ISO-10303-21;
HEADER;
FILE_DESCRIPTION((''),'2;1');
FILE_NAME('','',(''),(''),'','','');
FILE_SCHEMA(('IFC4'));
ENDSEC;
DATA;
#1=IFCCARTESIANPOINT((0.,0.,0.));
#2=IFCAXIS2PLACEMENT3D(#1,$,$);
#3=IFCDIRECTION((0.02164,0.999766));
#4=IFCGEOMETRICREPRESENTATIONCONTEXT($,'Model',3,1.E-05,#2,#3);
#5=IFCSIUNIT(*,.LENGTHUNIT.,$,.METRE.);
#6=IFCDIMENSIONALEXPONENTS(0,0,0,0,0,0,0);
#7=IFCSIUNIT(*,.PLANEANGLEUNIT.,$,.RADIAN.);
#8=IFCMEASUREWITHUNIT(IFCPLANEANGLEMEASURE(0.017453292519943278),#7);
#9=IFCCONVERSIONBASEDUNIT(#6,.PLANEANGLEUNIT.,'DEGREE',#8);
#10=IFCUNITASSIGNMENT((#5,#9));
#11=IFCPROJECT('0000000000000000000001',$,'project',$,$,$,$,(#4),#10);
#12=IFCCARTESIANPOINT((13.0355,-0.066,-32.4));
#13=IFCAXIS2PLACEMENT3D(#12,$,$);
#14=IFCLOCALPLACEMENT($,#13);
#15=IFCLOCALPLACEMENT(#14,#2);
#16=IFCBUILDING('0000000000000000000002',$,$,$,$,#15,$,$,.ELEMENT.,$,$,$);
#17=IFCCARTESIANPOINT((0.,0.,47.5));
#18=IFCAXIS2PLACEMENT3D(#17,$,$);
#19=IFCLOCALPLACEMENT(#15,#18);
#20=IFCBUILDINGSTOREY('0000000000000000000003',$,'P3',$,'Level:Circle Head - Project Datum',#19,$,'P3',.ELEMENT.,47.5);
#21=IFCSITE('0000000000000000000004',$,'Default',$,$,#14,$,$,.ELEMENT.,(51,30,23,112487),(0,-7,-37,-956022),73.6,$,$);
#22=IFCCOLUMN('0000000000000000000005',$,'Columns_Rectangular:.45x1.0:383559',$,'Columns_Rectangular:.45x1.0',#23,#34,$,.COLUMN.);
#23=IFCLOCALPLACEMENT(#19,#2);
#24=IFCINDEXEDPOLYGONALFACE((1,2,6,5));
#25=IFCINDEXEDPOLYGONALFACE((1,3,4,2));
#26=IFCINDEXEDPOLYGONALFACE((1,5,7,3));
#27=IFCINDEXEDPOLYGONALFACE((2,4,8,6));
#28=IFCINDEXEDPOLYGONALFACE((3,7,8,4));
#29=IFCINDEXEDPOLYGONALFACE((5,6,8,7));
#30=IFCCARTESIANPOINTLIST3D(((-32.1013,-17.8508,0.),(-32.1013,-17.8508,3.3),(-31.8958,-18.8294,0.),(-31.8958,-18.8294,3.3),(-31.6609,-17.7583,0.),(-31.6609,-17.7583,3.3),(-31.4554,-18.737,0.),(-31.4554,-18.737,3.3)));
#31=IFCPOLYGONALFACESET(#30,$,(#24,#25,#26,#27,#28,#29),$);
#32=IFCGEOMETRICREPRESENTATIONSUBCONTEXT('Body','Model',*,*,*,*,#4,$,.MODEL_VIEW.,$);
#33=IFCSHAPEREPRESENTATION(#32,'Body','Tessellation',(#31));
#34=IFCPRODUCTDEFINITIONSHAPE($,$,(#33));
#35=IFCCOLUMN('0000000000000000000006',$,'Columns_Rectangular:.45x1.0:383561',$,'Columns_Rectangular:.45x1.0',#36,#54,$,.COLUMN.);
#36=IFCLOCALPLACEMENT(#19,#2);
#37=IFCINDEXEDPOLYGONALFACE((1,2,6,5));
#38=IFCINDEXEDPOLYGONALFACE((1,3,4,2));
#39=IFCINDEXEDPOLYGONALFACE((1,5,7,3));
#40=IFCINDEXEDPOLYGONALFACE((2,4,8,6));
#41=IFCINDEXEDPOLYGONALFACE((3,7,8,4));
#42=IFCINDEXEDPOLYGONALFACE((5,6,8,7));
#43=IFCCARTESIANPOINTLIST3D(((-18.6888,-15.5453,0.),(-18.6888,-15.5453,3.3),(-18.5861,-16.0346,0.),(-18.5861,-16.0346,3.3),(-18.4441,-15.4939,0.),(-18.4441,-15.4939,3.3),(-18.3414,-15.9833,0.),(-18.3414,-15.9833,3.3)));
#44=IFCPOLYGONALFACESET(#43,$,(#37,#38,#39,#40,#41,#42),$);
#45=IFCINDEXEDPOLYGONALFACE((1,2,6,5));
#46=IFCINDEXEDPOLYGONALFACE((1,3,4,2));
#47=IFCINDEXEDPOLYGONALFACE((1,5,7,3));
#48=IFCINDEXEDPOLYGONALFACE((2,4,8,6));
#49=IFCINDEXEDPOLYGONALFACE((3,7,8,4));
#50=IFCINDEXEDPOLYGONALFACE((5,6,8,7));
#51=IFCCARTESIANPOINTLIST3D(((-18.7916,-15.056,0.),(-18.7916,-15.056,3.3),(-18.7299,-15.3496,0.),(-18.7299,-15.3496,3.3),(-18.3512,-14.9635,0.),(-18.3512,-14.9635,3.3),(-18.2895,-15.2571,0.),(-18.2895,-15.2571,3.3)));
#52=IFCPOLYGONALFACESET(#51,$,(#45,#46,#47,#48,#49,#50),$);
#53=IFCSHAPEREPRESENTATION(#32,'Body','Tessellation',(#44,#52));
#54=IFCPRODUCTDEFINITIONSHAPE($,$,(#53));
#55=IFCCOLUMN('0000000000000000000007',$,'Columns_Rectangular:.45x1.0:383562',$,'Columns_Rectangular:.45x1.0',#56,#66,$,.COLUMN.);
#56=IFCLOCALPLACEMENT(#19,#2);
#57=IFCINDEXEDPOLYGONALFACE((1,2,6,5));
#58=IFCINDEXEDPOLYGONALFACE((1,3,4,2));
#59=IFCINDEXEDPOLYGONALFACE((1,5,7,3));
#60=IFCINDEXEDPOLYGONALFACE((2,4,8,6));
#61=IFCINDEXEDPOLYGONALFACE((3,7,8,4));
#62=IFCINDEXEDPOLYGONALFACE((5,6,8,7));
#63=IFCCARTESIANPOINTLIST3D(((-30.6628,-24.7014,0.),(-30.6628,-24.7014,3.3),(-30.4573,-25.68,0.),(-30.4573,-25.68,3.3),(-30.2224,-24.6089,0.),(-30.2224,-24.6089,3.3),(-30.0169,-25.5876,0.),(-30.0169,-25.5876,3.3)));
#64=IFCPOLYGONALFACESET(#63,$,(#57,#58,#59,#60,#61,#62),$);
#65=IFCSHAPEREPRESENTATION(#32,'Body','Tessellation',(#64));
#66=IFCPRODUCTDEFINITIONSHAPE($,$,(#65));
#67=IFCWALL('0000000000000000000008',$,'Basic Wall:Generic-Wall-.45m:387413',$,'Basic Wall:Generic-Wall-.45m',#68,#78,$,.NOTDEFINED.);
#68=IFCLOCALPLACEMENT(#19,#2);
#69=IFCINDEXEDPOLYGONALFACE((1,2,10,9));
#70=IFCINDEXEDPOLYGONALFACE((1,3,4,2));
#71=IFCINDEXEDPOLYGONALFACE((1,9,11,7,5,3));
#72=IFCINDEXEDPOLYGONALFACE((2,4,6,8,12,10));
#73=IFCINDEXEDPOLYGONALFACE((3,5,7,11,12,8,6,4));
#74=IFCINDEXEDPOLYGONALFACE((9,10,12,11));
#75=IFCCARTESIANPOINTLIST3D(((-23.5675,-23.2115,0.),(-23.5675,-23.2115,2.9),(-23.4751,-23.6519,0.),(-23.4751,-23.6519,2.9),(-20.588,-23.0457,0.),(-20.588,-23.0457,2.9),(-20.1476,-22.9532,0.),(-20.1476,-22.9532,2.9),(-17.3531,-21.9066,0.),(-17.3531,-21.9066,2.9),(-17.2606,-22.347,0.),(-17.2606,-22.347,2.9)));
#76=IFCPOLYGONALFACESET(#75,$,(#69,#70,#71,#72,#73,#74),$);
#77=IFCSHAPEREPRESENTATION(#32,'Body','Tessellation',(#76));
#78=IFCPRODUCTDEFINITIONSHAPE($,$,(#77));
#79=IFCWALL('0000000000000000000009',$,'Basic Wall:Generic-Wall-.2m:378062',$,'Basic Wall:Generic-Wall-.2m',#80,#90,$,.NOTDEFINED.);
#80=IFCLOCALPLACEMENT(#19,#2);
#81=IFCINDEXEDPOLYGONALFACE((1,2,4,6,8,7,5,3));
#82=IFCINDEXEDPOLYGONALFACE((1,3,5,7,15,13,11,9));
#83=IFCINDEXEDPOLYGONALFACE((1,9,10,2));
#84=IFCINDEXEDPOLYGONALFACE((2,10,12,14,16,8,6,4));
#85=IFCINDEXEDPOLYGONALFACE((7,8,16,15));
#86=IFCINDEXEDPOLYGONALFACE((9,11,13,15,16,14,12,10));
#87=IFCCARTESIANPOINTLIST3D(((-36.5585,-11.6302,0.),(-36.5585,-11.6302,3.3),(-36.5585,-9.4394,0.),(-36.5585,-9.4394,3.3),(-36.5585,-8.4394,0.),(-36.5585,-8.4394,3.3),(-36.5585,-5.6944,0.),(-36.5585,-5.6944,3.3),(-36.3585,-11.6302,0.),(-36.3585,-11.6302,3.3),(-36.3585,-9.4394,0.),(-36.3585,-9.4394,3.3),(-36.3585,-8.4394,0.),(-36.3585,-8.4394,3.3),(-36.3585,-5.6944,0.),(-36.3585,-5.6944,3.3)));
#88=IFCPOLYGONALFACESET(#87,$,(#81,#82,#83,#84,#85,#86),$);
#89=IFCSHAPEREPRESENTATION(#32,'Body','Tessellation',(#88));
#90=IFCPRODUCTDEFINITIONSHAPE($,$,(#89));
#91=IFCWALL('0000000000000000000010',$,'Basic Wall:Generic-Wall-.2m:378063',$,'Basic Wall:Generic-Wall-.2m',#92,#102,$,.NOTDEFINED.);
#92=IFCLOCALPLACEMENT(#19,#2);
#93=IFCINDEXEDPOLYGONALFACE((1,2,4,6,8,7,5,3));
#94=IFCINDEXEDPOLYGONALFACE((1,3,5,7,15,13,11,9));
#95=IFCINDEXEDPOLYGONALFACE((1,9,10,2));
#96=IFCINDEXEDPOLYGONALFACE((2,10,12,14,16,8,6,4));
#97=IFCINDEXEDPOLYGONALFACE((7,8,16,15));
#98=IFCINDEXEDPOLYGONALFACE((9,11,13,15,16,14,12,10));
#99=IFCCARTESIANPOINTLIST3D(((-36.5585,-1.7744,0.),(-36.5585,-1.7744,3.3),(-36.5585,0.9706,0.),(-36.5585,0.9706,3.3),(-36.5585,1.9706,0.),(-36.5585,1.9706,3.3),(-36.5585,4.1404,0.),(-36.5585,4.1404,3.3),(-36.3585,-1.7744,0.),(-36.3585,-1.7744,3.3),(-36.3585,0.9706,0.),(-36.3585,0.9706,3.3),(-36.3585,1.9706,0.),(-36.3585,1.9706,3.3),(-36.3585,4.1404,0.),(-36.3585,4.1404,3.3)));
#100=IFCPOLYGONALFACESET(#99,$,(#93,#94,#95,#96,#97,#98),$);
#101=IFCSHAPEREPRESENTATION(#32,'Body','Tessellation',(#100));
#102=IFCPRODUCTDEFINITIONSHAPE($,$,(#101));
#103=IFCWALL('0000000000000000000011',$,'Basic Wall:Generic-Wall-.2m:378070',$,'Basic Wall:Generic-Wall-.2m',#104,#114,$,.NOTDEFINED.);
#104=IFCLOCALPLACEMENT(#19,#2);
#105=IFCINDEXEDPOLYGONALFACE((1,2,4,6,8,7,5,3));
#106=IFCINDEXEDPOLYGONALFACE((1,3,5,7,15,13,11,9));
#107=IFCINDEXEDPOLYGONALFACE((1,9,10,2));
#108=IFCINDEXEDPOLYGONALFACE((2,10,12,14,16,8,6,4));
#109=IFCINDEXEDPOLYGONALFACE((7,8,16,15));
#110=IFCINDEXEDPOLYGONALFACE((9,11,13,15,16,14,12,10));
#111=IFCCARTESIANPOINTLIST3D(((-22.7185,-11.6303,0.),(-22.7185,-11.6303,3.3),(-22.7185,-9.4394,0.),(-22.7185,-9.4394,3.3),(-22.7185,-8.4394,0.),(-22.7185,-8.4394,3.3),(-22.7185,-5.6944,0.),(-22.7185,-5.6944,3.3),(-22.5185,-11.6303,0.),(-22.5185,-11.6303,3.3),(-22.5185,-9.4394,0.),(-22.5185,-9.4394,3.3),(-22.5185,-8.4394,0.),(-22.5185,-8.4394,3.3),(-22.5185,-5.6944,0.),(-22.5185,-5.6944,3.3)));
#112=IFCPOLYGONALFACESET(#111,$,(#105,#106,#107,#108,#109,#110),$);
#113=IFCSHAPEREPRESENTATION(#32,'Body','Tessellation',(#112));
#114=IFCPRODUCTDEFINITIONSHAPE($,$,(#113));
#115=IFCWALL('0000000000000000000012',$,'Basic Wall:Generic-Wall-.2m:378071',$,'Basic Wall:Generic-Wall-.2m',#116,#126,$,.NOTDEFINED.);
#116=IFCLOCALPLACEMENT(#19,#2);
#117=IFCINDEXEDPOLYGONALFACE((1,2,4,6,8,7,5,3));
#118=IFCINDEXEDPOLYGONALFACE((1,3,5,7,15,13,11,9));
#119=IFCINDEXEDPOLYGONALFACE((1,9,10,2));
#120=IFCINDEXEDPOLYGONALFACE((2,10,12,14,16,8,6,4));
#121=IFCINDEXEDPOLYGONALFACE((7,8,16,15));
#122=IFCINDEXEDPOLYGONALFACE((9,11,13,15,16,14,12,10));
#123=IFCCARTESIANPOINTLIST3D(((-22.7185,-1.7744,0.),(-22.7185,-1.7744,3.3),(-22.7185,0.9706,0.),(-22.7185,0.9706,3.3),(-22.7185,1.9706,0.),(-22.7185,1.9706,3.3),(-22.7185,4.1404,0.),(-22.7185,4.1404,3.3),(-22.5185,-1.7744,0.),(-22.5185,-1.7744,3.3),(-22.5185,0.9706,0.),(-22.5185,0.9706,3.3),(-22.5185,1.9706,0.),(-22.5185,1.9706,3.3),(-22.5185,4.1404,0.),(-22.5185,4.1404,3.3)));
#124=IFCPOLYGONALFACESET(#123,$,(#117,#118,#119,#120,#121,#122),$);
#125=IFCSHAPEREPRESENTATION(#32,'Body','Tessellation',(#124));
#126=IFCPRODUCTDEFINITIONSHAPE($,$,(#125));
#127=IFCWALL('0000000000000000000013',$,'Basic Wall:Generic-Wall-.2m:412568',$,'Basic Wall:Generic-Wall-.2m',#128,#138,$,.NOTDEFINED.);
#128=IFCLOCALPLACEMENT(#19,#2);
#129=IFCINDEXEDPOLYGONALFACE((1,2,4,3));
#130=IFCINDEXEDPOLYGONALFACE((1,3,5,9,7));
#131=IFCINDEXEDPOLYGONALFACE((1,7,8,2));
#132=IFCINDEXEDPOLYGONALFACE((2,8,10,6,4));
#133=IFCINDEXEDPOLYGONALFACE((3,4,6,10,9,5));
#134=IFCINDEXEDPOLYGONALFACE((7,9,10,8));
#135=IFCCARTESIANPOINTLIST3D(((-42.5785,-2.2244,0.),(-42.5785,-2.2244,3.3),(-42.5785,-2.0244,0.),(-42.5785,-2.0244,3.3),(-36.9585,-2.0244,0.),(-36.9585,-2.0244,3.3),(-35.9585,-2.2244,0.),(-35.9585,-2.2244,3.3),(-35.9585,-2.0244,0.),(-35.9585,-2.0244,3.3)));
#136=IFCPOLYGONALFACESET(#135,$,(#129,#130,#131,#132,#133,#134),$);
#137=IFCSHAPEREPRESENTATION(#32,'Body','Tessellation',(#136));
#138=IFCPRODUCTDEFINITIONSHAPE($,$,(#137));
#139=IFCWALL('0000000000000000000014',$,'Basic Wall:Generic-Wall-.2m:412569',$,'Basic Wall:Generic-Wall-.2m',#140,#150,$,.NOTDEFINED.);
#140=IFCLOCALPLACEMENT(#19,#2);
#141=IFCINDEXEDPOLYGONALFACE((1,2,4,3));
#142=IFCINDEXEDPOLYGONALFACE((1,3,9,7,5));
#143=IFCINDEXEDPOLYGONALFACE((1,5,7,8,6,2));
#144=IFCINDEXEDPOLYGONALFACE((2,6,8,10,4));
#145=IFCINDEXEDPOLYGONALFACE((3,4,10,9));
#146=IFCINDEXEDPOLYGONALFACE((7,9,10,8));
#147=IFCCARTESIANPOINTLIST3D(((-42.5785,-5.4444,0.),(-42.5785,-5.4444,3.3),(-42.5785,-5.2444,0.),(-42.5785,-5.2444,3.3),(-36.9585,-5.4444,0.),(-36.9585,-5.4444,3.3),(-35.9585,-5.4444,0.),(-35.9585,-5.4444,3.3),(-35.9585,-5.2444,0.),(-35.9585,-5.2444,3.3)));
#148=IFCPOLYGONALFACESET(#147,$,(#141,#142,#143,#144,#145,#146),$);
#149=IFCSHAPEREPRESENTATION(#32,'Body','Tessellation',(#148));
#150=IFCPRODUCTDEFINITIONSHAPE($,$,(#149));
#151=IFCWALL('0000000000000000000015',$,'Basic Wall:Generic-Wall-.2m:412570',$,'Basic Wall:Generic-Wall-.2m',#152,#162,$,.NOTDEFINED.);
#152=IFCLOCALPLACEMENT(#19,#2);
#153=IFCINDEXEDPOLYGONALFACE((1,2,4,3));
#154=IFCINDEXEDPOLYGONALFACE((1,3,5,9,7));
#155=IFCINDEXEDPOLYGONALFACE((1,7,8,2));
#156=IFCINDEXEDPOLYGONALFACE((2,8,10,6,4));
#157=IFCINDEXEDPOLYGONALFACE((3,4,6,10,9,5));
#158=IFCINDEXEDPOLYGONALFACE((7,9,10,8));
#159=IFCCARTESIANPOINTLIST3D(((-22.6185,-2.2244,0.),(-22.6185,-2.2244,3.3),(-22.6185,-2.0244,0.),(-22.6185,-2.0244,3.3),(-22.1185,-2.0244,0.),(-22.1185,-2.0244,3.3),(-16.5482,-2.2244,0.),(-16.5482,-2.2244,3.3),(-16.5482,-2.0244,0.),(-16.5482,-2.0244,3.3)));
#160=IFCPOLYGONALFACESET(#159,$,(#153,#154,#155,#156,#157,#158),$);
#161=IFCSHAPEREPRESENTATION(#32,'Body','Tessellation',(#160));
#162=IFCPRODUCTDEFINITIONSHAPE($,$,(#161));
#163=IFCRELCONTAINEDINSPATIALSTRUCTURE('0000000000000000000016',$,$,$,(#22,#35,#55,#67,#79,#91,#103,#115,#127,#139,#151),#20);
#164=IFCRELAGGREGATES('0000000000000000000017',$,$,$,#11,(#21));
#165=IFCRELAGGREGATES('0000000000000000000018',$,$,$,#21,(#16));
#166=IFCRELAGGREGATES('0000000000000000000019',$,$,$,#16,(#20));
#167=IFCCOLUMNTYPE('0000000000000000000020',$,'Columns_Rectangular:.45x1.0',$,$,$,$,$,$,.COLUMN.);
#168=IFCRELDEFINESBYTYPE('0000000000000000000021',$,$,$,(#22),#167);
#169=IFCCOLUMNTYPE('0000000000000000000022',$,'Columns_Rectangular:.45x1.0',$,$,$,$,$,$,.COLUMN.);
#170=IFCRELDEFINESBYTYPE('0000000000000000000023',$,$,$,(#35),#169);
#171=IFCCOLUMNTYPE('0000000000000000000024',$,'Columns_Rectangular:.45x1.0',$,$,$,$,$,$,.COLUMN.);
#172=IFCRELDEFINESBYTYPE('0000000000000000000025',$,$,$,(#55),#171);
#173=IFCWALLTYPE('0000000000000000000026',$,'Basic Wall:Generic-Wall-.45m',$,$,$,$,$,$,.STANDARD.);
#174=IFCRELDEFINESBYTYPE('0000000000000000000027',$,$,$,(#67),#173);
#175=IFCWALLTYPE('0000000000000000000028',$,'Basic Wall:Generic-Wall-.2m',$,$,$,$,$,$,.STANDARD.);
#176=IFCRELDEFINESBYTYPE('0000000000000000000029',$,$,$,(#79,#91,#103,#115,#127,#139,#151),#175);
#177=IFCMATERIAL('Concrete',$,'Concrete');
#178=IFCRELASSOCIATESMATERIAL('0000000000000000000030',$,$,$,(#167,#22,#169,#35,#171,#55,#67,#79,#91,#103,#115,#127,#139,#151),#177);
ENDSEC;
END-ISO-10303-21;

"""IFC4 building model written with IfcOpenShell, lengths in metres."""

from ifc_helpers import new_model, entity, si_unit, converted_unit, direction, frame, origin, place, context, subcontext, project, spatial, indexed_curve, outline, extrude, source, transform, mapped, material, type_object, type_shapes, element, save


model = new_model("IFC4")

# Units and contexts
model_context = context("Model", 3, precision=1e-05, world=origin(), true_north=direction((0.02164, 0.999766)))
body_context = subcontext(model_context, "Body", "Model", "MODEL_VIEW")
ifc_project = project(units=[si_unit("LENGTHUNIT", "METRE"), converted_unit("PLANEANGLEUNIT", "DEGREE", entity("IfcPlaneAngleMeasure", 0.017453292519943278), si_unit("PLANEANGLEUNIT", "RADIAN"), dimensions=[0, 0, 0, 0, 0, 0, 0])], contexts=[model_context])

# Site, building, storey
site_placement = place(None, frame((13.0355, -0.066, -32.4)))
site = spatial("IfcSite", under=ifc_project, at=site_placement, Name="Default", CompositionType="ELEMENT", RefLatitude=(51, 30, 23, 112487), RefLongitude=(0, -7, -37, -956022), RefElevation=73.6)
building_placement = place(site_placement, origin())
building = spatial("IfcBuilding", under=site, at=building_placement, CompositionType="ELEMENT")
storey_placement = place(building_placement, frame((0.0, 0.0, 47.5)))
storey = spatial("IfcBuildingStorey", under=building, at=storey_placement, Name="P3", ObjectType="Level:Circle Head - Project Datum", LongName="P3", CompositionType="ELEMENT", Elevation=47.5)

# Columns
ifc_material = material(Name="Concrete", Category="Concrete")
column_type_1 = type_object("IfcColumnType", Name="Columns_Rectangular:.45x1.0", PredefinedType="COLUMN", material=ifc_material)
shared_shape_1 = source(origin(), body_context, "Body", "SweptSolid", [
    extrude(outline(indexed_curve([(-0.5, -0.225), (0.5, -0.225), (0.5, 0.225), (-0.5, 0.225), (-0.5, -0.225)], self_intersect=False)), frame((-31.7784, -18.2939, 47.5), z_axis=(0.0, 0.0, 1.0), x_axis=(-0.2055, 0.978657, 0.0)), (0.0, 0.0, 1.0), 3.3),
])
type_shapes(column_type_1, [shared_shape_1])
column_1_placement = place(storey_placement, frame((0.0, 0.0, -47.5)))
element("IfcColumn", 1, at=column_1_placement, inside=storey, type_object=column_type_1, material=ifc_material, Name="Columns_Rectangular:.45x1.0:383559", ObjectType="Columns_Rectangular:.45x1.0", PredefinedType="COLUMN", context=body_context, shape_type="MappedRepresentation", body=[
    mapped(shared_shape_1, transform((0.0, 0.0, 0.0), scale=1.0)),
])
column_type_2 = type_object("IfcColumnType", Name="Columns_Rectangular:.45x1.0", PredefinedType="COLUMN", material=ifc_material)
shared_shape_2 = source(origin(), body_context, "Body", "SweptSolid", [
    extrude(outline(indexed_curve([(-0.125, -0.25), (0.125, -0.25), (0.125, 0.25), (-0.125, 0.25), (-0.125, -0.25)], self_intersect=False)), frame((-18.5151, -15.7643, 47.5), z_axis=(0.0, 0.0, 1.0), x_axis=(0.978657, 0.2055, 0.0)), (0.0, 0.0, 1.0), 3.3),
    extrude(outline(indexed_curve([(-0.15, -0.225), (0.15, -0.225), (0.15, 0.225), (-0.15, 0.225), (-0.15, -0.225)], self_intersect=False)), frame((-18.5405, -15.1565, 47.5), z_axis=(0.0, 0.0, 1.0), x_axis=(0.2055, -0.978657, 0.0)), (0.0, 0.0, 1.0), 3.3),
])
type_shapes(column_type_2, [shared_shape_2])
column_2_placement = place(storey_placement, frame((0.0, 0.0, -47.5)))
element("IfcColumn", 2, at=column_2_placement, inside=storey, type_object=column_type_2, material=ifc_material, Name="Columns_Rectangular:.45x1.0:383561", ObjectType="Columns_Rectangular:.45x1.0", PredefinedType="COLUMN", context=body_context, shape_type="MappedRepresentation", body=[
    mapped(shared_shape_2, transform((0.0, 0.0, 0.0), scale=1.0)),
])
column_type_3 = type_object("IfcColumnType", Name="Columns_Rectangular:.45x1.0", PredefinedType="COLUMN", material=ifc_material)
shared_shape_3 = source(origin(), body_context, "Body", "SweptSolid", [
    extrude(outline(indexed_curve([(-0.5, -0.225), (0.5, -0.225), (0.5, 0.225), (-0.5, 0.225), (-0.5, -0.225)], self_intersect=False)), frame((-30.3399, -25.1445, 47.5), z_axis=(0.0, 0.0, 1.0), x_axis=(-0.2055, 0.978657, 0.0)), (0.0, 0.0, 1.0), 3.3),
])
type_shapes(column_type_3, [shared_shape_3])
column_3_placement = place(storey_placement, frame((0.0, 0.0, -47.5)))
element("IfcColumn", 3, at=column_3_placement, inside=storey, type_object=column_type_3, material=ifc_material, Name="Columns_Rectangular:.45x1.0:383562", ObjectType="Columns_Rectangular:.45x1.0", PredefinedType="COLUMN", context=body_context, shape_type="MappedRepresentation", body=[
    mapped(shared_shape_3, transform((0.0, 0.0, 0.0), scale=1.0)),
])

# Walls
wall_type_1 = type_object("IfcWallType", Name="Basic Wall:Generic-Wall-.45m", PredefinedType="STANDARD")
wall_1_placement = place(storey_placement, frame((-23.5213, -23.4317, 0.0), z_axis=(0.0, 0.0, 1.0), x_axis=(0.978657, 0.2055, 0.0)))
element("IfcWall", 4, at=wall_1_placement, inside=storey, type_object=wall_type_1, material=ifc_material, Name="Basic Wall:Generic-Wall-.45m:387413", ObjectType="Basic Wall:Generic-Wall-.45m", PredefinedType="NOTDEFINED", context=body_context, shape_type="SweptSolid", body=[
    extrude(outline(indexed_curve([(6.35, -0.225), (6.35, 0.225), (0.0, 0.225), (0.0, -0.225), (2.95, -0.225), (3.4, -0.225), (6.35, -0.225)], self_intersect=False)), origin(), (0.0, 0.0, 1.0), 2.9),
])
wall_type_2 = type_object("IfcWallType", Name="Basic Wall:Generic-Wall-.2m", PredefinedType="STANDARD")
wall_2_placement = place(storey_placement, frame((-36.4585, -5.6944, 0.0), z_axis=(0.0, 0.0, 1.0), x_axis=(0.0, -1.0, 0.0)))
element("IfcWall", 5, at=wall_2_placement, inside=storey, type_object=wall_type_2, material=ifc_material, Name="Basic Wall:Generic-Wall-.2m:378062", ObjectType="Basic Wall:Generic-Wall-.2m", PredefinedType="NOTDEFINED", context=body_context, shape_type="SweptSolid", body=[
    extrude(outline(indexed_curve([(5.9357, -0.1), (5.9357, 0.1), (3.745, 0.1), (2.745, 0.1), (0.0, 0.1), (0.0, -0.1), (2.745, -0.1), (3.745, -0.1), (5.9357, -0.1)], self_intersect=False)), origin(), (0.0, 0.0, 1.0), 3.3),
])
wall_3_placement = place(storey_placement, frame((-36.4585, -1.7744, 0.0), z_axis=(0.0, 0.0, 1.0), x_axis=(0.0, 1.0, 0.0)))
element("IfcWall", 6, at=wall_3_placement, inside=storey, type_object=wall_type_2, material=ifc_material, Name="Basic Wall:Generic-Wall-.2m:378063", ObjectType="Basic Wall:Generic-Wall-.2m", PredefinedType="NOTDEFINED", context=body_context, shape_type="SweptSolid", body=[
    extrude(outline(indexed_curve([(5.9149, -0.1), (5.9149, 0.1), (3.745, 0.1), (2.745, 0.1), (0.0, 0.1), (0.0, -0.1), (2.745, -0.1), (3.745, -0.1), (5.9149, -0.1)], self_intersect=False)), origin(), (0.0, 0.0, 1.0), 3.3),
])
wall_4_placement = place(storey_placement, frame((-22.6185, -5.6944, 0.0), z_axis=(0.0, 0.0, 1.0), x_axis=(0.0, -1.0, 0.0)))
element("IfcWall", 7, at=wall_4_placement, inside=storey, type_object=wall_type_2, material=ifc_material, Name="Basic Wall:Generic-Wall-.2m:378070", ObjectType="Basic Wall:Generic-Wall-.2m", PredefinedType="NOTDEFINED", context=body_context, shape_type="SweptSolid", body=[
    extrude(outline(indexed_curve([(5.9358, -0.1), (5.9359, 0.1), (3.745, 0.1), (2.745, 0.1), (0.0, 0.1), (0.0, -0.1), (2.745, -0.1), (3.745, -0.1), (5.9358, -0.1)], self_intersect=False)), origin(), (0.0, 0.0, 1.0), 3.3),
])
wall_5_placement = place(storey_placement, frame((-22.6185, -1.7744, 0.0), z_axis=(0.0, 0.0, 1.0), x_axis=(0.0, 1.0, 0.0)))
element("IfcWall", 8, at=wall_5_placement, inside=storey, type_object=wall_type_2, material=ifc_material, Name="Basic Wall:Generic-Wall-.2m:378071", ObjectType="Basic Wall:Generic-Wall-.2m", PredefinedType="NOTDEFINED", context=body_context, shape_type="SweptSolid", body=[
    extrude(outline(indexed_curve([(5.9149, -0.1), (5.9149, 0.1), (3.745, 0.1), (2.745, 0.1), (0.0, 0.1), (0.0, -0.1), (2.745, -0.1), (3.745, -0.1), (5.9149, -0.1)], self_intersect=False)), origin(), (0.0, 0.0, 1.0), 3.3),
])
wall_6_placement = place(storey_placement, frame((-35.9585, -2.1244, 0.0), z_axis=(0.0, 0.0, 1.0), x_axis=(-1.0, 0.0, 0.0)))
element("IfcWall", 9, at=wall_6_placement, inside=storey, type_object=wall_type_2, material=ifc_material, Name="Basic Wall:Generic-Wall-.2m:412568", ObjectType="Basic Wall:Generic-Wall-.2m", PredefinedType="NOTDEFINED", context=body_context, shape_type="SweptSolid", body=[
    extrude(outline(indexed_curve([(6.6201, -0.1), (6.6201, 0.1), (0.0, 0.1), (0.0, -0.1), (1.0, -0.1), (6.6201, -0.1)], self_intersect=False)), origin(), (0.0, 0.0, 1.0), 3.3),
])
wall_7_placement = place(storey_placement, frame((-35.9585, -5.3444, 0.0), z_axis=(0.0, 0.0, 1.0), x_axis=(-1.0, 0.0, 0.0)))
element("IfcWall", 10, at=wall_7_placement, inside=storey, type_object=wall_type_2, material=ifc_material, Name="Basic Wall:Generic-Wall-.2m:412569", ObjectType="Basic Wall:Generic-Wall-.2m", PredefinedType="NOTDEFINED", context=body_context, shape_type="SweptSolid", body=[
    extrude(outline(indexed_curve([(6.62, -0.1), (6.62, 0.1), (1.0, 0.1), (0.0, 0.1), (0.0, -0.1), (6.62, -0.1)], self_intersect=False)), origin(), (0.0, 0.0, 1.0), 3.3),
])
wall_8_placement = place(storey_placement, frame((-22.6185, -2.1244, 0.0)))
element("IfcWall", 11, at=wall_8_placement, inside=storey, type_object=wall_type_2, material=ifc_material, Name="Basic Wall:Generic-Wall-.2m:412570", ObjectType="Basic Wall:Generic-Wall-.2m", PredefinedType="NOTDEFINED", context=body_context, shape_type="SweptSolid", body=[
    extrude(outline(indexed_curve([(6.0702, -0.1), (6.0702, 0.1), (0.5, 0.1), (0.0, 0.1), (0.0, -0.1), (6.0702, -0.1)], self_intersect=False)), origin(), (0.0, 0.0, 1.0), 3.3),
])

save(model, "model.ifc")
